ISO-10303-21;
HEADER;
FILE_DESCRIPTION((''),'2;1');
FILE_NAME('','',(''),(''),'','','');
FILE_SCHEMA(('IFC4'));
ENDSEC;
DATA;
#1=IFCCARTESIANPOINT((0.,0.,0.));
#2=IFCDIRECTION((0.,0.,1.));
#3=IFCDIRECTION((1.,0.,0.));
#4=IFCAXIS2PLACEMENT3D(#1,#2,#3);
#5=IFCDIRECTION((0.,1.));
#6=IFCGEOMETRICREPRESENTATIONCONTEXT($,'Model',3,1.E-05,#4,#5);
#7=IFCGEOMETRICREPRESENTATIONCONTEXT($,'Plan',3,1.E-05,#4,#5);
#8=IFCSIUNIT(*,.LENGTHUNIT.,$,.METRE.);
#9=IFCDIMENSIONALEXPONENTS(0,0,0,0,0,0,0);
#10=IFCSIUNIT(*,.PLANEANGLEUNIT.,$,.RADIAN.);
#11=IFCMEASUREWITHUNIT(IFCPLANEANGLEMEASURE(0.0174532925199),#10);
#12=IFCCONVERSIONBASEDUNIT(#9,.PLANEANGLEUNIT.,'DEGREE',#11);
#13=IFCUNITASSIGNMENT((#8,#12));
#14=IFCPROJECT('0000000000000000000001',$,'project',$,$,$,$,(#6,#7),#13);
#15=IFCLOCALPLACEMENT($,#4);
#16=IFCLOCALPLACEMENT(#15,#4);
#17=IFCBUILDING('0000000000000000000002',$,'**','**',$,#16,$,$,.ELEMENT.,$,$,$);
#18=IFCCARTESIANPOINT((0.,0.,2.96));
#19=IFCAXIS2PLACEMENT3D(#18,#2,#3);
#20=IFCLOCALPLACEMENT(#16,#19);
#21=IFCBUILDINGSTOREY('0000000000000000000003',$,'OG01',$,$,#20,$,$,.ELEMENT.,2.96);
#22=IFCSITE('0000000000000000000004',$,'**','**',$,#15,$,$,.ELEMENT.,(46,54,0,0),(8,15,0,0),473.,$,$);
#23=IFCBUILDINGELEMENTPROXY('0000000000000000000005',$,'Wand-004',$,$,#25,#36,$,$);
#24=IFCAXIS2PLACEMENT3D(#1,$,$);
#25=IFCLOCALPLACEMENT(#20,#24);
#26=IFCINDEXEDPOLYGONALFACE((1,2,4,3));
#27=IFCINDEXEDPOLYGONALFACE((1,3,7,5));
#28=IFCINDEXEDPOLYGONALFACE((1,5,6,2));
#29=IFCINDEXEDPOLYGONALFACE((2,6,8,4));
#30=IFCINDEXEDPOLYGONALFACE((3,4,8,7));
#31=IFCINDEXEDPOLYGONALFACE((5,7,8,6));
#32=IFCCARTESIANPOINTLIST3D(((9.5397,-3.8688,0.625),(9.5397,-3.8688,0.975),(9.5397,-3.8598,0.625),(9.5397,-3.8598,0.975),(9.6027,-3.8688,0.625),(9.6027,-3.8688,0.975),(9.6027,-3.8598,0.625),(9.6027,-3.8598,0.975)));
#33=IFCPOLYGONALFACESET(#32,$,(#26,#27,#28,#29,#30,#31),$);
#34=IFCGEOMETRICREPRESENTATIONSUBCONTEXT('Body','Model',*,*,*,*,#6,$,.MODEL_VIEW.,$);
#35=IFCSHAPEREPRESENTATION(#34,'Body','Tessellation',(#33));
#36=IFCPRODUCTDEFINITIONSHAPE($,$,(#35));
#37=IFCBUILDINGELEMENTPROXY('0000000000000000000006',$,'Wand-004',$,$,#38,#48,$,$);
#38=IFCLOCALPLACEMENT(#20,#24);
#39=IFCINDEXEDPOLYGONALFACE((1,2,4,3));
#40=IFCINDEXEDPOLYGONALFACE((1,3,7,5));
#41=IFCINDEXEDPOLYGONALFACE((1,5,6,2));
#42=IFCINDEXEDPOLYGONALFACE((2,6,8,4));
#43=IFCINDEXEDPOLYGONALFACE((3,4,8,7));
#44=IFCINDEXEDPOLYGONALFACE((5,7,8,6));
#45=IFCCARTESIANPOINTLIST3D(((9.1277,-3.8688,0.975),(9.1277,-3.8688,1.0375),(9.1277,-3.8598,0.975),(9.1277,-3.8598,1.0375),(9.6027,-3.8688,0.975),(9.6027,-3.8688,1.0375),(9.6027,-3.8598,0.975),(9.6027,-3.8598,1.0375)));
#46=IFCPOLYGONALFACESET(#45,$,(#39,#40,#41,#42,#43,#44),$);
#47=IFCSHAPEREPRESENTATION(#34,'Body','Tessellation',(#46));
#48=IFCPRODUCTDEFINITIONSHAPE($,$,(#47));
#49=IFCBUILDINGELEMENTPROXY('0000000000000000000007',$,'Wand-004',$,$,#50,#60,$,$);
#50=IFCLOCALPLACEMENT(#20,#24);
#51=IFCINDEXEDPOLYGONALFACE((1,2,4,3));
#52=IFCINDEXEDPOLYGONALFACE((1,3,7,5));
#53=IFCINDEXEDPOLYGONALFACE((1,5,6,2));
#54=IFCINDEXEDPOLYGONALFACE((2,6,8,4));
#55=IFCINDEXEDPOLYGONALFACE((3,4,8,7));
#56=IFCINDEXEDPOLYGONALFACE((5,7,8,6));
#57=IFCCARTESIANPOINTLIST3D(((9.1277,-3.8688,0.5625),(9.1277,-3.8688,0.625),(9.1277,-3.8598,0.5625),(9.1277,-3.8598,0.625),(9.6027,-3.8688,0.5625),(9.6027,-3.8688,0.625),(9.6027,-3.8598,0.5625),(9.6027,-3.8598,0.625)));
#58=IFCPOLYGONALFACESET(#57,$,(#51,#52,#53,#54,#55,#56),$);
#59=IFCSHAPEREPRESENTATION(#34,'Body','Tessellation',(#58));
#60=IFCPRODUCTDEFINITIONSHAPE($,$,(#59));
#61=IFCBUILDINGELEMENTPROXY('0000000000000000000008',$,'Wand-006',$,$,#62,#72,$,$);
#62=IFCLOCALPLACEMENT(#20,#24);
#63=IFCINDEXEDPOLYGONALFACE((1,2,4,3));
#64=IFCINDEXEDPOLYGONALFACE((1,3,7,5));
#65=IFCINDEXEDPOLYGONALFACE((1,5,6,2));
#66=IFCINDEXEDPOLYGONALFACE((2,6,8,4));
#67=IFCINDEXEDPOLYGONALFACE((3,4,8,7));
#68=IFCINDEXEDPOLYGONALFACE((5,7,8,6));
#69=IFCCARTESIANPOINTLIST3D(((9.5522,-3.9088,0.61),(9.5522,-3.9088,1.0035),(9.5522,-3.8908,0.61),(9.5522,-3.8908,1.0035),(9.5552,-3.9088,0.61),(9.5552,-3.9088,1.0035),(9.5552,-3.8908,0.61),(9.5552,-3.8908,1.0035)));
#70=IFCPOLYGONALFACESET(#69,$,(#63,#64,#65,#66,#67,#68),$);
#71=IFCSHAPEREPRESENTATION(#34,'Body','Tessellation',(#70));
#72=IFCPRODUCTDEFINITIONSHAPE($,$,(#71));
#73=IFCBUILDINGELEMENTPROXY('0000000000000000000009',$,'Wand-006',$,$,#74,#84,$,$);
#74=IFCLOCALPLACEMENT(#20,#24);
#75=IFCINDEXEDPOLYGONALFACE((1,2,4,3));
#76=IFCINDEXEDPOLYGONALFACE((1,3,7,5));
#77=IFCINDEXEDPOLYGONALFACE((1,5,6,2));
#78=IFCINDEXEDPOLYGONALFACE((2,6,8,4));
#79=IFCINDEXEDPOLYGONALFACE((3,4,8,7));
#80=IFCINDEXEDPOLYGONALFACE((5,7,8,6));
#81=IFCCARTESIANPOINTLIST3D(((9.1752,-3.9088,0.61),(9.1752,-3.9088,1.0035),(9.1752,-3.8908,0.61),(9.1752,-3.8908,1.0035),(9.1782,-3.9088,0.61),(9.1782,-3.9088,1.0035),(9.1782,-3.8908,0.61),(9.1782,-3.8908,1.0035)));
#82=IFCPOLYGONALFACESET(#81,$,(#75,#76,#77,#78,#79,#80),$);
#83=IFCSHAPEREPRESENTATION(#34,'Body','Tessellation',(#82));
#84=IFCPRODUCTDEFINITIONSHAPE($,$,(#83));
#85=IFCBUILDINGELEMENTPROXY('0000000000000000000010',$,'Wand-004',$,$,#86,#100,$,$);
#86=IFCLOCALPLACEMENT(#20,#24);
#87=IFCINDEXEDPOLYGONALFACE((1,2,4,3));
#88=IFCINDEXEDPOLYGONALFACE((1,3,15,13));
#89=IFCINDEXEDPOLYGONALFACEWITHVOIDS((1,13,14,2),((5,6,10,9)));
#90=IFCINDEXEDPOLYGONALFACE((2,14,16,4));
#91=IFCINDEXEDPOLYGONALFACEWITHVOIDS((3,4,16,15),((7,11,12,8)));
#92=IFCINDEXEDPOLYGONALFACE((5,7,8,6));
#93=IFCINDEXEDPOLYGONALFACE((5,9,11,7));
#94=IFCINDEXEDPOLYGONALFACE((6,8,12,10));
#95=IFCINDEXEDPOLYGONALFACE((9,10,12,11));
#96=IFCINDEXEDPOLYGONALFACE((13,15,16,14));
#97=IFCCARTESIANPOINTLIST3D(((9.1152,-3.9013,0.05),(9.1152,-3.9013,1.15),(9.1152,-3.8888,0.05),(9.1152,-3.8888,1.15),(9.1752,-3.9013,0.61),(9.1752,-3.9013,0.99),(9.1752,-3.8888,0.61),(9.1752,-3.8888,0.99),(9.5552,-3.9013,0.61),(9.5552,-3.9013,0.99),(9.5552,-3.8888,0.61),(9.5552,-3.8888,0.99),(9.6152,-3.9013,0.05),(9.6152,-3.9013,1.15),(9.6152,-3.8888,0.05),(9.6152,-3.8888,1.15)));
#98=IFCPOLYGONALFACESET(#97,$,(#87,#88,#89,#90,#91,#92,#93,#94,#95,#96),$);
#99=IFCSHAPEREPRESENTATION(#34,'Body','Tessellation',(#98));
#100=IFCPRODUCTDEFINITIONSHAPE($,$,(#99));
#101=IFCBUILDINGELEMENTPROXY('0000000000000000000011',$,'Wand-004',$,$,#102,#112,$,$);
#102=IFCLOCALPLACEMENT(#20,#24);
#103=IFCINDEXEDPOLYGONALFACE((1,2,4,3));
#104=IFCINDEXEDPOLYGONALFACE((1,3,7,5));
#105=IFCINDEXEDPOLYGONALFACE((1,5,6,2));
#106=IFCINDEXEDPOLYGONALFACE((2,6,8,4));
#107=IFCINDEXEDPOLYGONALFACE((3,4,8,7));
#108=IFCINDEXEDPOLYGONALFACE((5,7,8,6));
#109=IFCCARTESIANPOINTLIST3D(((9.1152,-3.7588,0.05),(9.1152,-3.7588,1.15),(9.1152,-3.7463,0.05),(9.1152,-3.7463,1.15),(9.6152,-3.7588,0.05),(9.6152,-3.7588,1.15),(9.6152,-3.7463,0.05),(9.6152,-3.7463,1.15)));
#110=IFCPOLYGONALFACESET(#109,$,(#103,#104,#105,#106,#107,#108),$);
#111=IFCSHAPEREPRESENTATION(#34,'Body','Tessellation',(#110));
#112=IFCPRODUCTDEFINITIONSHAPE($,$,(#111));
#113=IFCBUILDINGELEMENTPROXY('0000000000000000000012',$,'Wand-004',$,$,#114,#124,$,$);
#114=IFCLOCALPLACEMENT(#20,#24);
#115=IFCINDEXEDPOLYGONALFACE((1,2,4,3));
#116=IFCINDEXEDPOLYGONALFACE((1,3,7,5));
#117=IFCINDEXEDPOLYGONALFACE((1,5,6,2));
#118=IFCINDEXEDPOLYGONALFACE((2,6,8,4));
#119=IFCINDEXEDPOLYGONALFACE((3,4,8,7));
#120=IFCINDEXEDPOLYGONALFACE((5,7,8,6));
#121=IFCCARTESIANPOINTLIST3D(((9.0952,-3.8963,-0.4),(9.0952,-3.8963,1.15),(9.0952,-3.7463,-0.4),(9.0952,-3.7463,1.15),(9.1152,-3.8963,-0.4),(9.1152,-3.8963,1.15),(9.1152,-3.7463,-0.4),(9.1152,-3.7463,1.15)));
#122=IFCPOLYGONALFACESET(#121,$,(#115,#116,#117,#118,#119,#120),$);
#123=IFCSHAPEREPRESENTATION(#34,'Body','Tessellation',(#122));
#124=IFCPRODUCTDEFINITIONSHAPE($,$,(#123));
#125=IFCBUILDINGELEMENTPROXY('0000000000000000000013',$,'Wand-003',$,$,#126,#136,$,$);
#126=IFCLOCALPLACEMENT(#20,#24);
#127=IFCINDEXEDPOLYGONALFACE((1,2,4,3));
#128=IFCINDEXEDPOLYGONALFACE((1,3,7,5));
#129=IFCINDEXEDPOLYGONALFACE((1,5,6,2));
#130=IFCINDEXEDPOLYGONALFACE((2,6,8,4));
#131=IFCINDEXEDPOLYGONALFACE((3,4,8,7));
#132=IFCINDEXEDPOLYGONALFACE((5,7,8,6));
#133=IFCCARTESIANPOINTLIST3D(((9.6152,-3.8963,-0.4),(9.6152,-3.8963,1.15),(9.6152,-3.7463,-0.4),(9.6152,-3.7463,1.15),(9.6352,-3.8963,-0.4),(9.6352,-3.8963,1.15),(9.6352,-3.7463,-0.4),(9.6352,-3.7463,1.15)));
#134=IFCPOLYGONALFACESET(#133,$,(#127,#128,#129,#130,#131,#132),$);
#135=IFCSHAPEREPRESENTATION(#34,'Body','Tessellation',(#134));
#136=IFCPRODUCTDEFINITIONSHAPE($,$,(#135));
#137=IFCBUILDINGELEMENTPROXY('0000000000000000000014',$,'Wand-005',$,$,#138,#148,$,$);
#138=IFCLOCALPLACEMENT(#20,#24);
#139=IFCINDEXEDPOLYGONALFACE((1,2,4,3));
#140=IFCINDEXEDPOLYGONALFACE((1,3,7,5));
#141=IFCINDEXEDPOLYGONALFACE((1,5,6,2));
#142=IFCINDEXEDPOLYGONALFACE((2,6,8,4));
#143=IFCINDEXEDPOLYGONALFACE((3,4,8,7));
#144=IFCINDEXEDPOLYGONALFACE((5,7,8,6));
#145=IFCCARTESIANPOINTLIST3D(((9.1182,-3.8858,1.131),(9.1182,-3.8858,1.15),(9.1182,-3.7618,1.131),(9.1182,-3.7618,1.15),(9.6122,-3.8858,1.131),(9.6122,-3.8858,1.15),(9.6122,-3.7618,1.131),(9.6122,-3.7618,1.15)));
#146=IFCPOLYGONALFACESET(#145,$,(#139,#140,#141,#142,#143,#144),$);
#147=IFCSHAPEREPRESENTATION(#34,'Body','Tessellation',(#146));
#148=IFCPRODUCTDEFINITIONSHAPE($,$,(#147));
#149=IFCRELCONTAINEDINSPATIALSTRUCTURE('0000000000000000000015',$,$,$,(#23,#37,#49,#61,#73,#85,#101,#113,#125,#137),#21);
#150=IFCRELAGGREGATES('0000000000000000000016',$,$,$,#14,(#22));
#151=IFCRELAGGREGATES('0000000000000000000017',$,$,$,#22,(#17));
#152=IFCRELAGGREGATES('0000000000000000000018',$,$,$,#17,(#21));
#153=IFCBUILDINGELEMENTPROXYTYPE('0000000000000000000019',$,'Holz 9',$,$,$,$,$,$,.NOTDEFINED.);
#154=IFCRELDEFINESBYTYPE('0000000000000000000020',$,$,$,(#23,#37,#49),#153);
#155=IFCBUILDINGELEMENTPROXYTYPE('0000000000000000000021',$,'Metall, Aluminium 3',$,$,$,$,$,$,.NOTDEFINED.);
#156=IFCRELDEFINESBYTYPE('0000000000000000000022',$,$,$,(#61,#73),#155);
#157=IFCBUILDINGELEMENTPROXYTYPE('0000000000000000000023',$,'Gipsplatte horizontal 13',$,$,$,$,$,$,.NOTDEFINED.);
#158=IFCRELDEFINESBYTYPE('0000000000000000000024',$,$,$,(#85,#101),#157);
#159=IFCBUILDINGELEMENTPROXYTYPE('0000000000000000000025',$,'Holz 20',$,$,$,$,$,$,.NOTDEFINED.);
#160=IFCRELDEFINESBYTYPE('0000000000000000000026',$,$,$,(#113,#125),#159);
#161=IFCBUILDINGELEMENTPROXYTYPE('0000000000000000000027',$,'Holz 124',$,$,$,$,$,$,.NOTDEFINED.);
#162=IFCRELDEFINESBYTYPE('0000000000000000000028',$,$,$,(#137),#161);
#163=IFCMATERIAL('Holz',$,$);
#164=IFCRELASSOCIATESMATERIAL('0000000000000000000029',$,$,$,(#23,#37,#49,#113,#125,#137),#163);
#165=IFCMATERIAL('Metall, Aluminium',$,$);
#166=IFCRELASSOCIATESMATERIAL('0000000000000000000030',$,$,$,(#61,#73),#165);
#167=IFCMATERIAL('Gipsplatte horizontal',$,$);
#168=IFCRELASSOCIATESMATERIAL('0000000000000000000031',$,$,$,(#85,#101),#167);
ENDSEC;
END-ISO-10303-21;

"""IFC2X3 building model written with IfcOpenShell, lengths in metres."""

from ifc_helpers import new_model, entity, si_unit, converted_unit, direction, frame, origin_with_axes, origin_2d_with_axis, place, context, subcontext, project, spatial, polyline, rectangle, outline, extrude, material, type_object, element, save


model = new_model("IFC2X3")

# Units and contexts
model_context = context("Model", 3, precision=1e-05, world=origin_with_axes(), true_north=direction((0.0, 1.0)))
plan_context = context("Plan", 3, precision=1e-05, world=origin_with_axes(), true_north=direction((0.0, 1.0)))
body_context = subcontext(model_context, "Body", "Model", "MODEL_VIEW")
ifc_project = project(units=[si_unit("LENGTHUNIT", "METRE"), converted_unit("PLANEANGLEUNIT", "DEGREE", entity("IfcPlaneAngleMeasure", 0.0174532925199), si_unit("PLANEANGLEUNIT", "RADIAN"), dimensions=[0, 0, 0, 0, 0, 0, 0])], contexts=[model_context, plan_context])

# Site, building, storey
site_placement = place(None, origin_with_axes())
site = spatial("IfcSite", under=ifc_project, at=site_placement, Name="**", Description="**", CompositionType="ELEMENT", RefLatitude=(46, 54, 0, 0), RefLongitude=(8, 15, 0, 0), RefElevation=473.0)
building_placement = place(site_placement, origin_with_axes())
building = spatial("IfcBuilding", under=site, at=building_placement, Name="**", Description="**", CompositionType="ELEMENT")
storey_placement = place(building_placement, frame((0.0, 0.0, 2.96), z_axis=(0.0, 0.0, 1.0), x_axis=(1.0, 0.0, 0.0)))
storey = spatial("IfcBuildingStorey", under=building, at=storey_placement, Name="OG01", CompositionType="ELEMENT", Elevation=2.96)

# Building element proxies
ifc_material_1 = material(Name="Holz")
building_element_proxy_type_1 = type_object("IfcBuildingElementProxyType", Name="Holz 9", PredefinedType="NOTDEFINED")
for number, where, z_axis, x_axis, name in (
    (1, (9.5397, -3.8688, 0.625), (0.0, 0.0, 1.0), (1.0, 0.0, 0.0), "Wand-004"),
):
    element("IfcBuildingElementProxy", number, at=place(storey_placement, frame(where, z_axis=z_axis, x_axis=x_axis)), inside=storey, type_object=building_element_proxy_type_1, material=ifc_material_1, Name=name, context=body_context, shape_type="SweptSolid", body=[
        extrude(outline(polyline([(0.0, 0.0), (0.063, 0.0), (0.063, 0.009), (0.0, 0.009), (0.0, 0.0)])), origin_with_axes(), (0.0, 0.0, 1.0), 0.35),
    ])
for number, where, z_axis, x_axis, name in (
    (2, (9.6027, -3.8688, 0.975), (0.0, 0.0, 1.0), (-1.0, 0.0, 0.0), "Wand-004"),
    (3, (9.6027, -3.8688, 0.5625), (0.0, 0.0, 1.0), (-1.0, 0.0, 0.0), "Wand-004"),
):
    element("IfcBuildingElementProxy", number, at=place(storey_placement, frame(where, z_axis=z_axis, x_axis=x_axis)), inside=storey, type_object=building_element_proxy_type_1, material=ifc_material_1, Name=name, context=body_context, shape_type="SweptSolid", body=[
        extrude(outline(polyline([(0.0, -0.009), (0.475, -0.009), (0.475, 0.0), (0.0, 0.0), (0.0, -0.009)])), origin_with_axes(), (0.0, 0.0, 1.0), 0.0625),
    ])
ifc_material_2 = material(Name="Metall, Aluminium")
building_element_proxy_type_2 = type_object("IfcBuildingElementProxyType", Name="Metall, Aluminium 3", PredefinedType="NOTDEFINED")
proxy_1_placement = place(storey_placement, frame((9.5552, -3.8908, 0.61), z_axis=(0.0, 0.0, 1.0), x_axis=(0.0, -1.0, 0.0)))
element("IfcBuildingElementProxy", 4, at=proxy_1_placement, inside=storey, type_object=building_element_proxy_type_2, material=ifc_material_2, Name="Wand-006", context=body_context, shape_type="SweptSolid", body=[
    extrude(outline(polyline([(0.0, -0.003), (0.018, -0.003), (0.018, 0.0), (0.0, 0.0), (0.0, -0.003)])), origin_with_axes(), (0.0, 0.0, 1.0), 0.3935),
])
proxy_2_placement = place(storey_placement, frame((9.1752, -3.8908, 0.61), z_axis=(0.0, 0.0, 1.0), x_axis=(0.0, -1.0, 0.0)))
element("IfcBuildingElementProxy", 5, at=proxy_2_placement, inside=storey, type_object=building_element_proxy_type_2, material=ifc_material_2, Name="Wand-006", context=body_context, shape_type="SweptSolid", body=[
    extrude(outline(polyline([(0.0, 0.0), (0.018, 0.0), (0.018, 0.003), (0.0, 0.003), (0.0, 0.0)])), origin_with_axes(), (0.0, 0.0, 1.0), 0.3935),
])

# Building element proxy, opening
ifc_material_3 = material(Name="Gipsplatte horizontal")
building_element_proxy_type_3 = type_object("IfcBuildingElementProxyType", Name="Gipsplatte horizontal 13", PredefinedType="NOTDEFINED")
proxy_3_placement = place(storey_placement, frame((9.1152, -3.9013, 0.05), z_axis=(0.0, 0.0, 1.0), x_axis=(1.0, 0.0, 0.0)))
proxy_3 = element("IfcBuildingElementProxy", 6, at=proxy_3_placement, inside=storey, type_object=building_element_proxy_type_3, material=ifc_material_3, Name="Wand-004", context=body_context, shape_type="SweptSolid", body=[
    extrude(outline(polyline([(0.0, 0.0), (0.5, 0.0), (0.5, 0.0125), (0.0, 0.0125), (0.0, 0.0)])), origin_with_axes(), (0.0, 0.0, 1.0), 1.1),
])
opening_placement = place(proxy_3_placement, frame((-9.1152, 3.9013, -3.01), z_axis=(0.0, 0.0, 1.0), x_axis=(1.0, 0.0, 0.0)))
element("IfcOpeningElement", 7, at=opening_placement, cuts=proxy_3, context=body_context, shape_type="SweptSolid", body=[
    extrude(rectangle(XDim=0.38, YDim=0.38, at=origin_2d_with_axis()), frame((9.3652, -3.9138, 3.76), z_axis=(0.0, -1.0, 0.0), x_axis=(1.0, 0.0, 0.0)), (0.0, 0.0, -1.0), 0.0375),
])

# Building element proxies
proxy_4_placement = place(storey_placement, frame((9.1152, -3.7463, 0.05), z_axis=(0.0, 0.0, 1.0), x_axis=(1.0, 0.0, 0.0)))
element("IfcBuildingElementProxy", 8, at=proxy_4_placement, inside=storey, type_object=building_element_proxy_type_3, material=ifc_material_3, Name="Wand-004", context=body_context, shape_type="SweptSolid", body=[
    extrude(outline(polyline([(0.0, -0.0125), (0.5, -0.0125), (0.5, 0.0), (0.0, 0.0), (0.0, -0.0125)])), origin_with_axes(), (0.0, 0.0, 1.0), 1.1),
])
building_element_proxy_type_4 = type_object("IfcBuildingElementProxyType", Name="Holz 20", PredefinedType="NOTDEFINED")
proxy_5_placement = place(storey_placement, frame((9.0952, -3.7463, -0.4), z_axis=(0.0, 0.0, 1.0), x_axis=(0.0, -1.0, 0.0)))
element("IfcBuildingElementProxy", 9, at=proxy_5_placement, inside=storey, type_object=building_element_proxy_type_4, material=ifc_material_1, Name="Wand-004", context=body_context, shape_type="SweptSolid", body=[
    extrude(outline(polyline([(0.0, 0.0), (0.15, 0.0), (0.15, 0.02), (0.0, 0.02), (0.0, 0.0)])), origin_with_axes(), (0.0, 0.0, 1.0), 1.55),
])
proxy_6_placement = place(storey_placement, frame((9.6352, -3.7463, -0.4), z_axis=(0.0, 0.0, 1.0), x_axis=(0.0, -1.0, 0.0)))
element("IfcBuildingElementProxy", 10, at=proxy_6_placement, inside=storey, type_object=building_element_proxy_type_4, material=ifc_material_1, Name="Wand-003", context=body_context, shape_type="SweptSolid", body=[
    extrude(outline(polyline([(0.0, -0.02), (0.15, -0.02), (0.15, 0.0), (0.0, 0.0), (0.0, -0.02)])), origin_with_axes(), (0.0, 0.0, 1.0), 1.55),
])
building_element_proxy_type_5 = type_object("IfcBuildingElementProxyType", Name="Holz 124", PredefinedType="NOTDEFINED")
proxy_7_placement = place(storey_placement, frame((9.1182, -3.7618, 1.131), z_axis=(0.0, 0.0, 1.0), x_axis=(1.0, 0.0, 0.0)))
element("IfcBuildingElementProxy", 11, at=proxy_7_placement, inside=storey, type_object=building_element_proxy_type_5, material=ifc_material_1, Name="Wand-005", context=body_context, shape_type="SweptSolid", body=[
    extrude(outline(polyline([(0.0, -0.124), (0.494, -0.124), (0.494, 0.0), (0.0, 0.0), (0.0, -0.124)])), origin_with_axes(), (0.0, 0.0, 1.0), 0.019),
])

save(model, "model.ifc")
